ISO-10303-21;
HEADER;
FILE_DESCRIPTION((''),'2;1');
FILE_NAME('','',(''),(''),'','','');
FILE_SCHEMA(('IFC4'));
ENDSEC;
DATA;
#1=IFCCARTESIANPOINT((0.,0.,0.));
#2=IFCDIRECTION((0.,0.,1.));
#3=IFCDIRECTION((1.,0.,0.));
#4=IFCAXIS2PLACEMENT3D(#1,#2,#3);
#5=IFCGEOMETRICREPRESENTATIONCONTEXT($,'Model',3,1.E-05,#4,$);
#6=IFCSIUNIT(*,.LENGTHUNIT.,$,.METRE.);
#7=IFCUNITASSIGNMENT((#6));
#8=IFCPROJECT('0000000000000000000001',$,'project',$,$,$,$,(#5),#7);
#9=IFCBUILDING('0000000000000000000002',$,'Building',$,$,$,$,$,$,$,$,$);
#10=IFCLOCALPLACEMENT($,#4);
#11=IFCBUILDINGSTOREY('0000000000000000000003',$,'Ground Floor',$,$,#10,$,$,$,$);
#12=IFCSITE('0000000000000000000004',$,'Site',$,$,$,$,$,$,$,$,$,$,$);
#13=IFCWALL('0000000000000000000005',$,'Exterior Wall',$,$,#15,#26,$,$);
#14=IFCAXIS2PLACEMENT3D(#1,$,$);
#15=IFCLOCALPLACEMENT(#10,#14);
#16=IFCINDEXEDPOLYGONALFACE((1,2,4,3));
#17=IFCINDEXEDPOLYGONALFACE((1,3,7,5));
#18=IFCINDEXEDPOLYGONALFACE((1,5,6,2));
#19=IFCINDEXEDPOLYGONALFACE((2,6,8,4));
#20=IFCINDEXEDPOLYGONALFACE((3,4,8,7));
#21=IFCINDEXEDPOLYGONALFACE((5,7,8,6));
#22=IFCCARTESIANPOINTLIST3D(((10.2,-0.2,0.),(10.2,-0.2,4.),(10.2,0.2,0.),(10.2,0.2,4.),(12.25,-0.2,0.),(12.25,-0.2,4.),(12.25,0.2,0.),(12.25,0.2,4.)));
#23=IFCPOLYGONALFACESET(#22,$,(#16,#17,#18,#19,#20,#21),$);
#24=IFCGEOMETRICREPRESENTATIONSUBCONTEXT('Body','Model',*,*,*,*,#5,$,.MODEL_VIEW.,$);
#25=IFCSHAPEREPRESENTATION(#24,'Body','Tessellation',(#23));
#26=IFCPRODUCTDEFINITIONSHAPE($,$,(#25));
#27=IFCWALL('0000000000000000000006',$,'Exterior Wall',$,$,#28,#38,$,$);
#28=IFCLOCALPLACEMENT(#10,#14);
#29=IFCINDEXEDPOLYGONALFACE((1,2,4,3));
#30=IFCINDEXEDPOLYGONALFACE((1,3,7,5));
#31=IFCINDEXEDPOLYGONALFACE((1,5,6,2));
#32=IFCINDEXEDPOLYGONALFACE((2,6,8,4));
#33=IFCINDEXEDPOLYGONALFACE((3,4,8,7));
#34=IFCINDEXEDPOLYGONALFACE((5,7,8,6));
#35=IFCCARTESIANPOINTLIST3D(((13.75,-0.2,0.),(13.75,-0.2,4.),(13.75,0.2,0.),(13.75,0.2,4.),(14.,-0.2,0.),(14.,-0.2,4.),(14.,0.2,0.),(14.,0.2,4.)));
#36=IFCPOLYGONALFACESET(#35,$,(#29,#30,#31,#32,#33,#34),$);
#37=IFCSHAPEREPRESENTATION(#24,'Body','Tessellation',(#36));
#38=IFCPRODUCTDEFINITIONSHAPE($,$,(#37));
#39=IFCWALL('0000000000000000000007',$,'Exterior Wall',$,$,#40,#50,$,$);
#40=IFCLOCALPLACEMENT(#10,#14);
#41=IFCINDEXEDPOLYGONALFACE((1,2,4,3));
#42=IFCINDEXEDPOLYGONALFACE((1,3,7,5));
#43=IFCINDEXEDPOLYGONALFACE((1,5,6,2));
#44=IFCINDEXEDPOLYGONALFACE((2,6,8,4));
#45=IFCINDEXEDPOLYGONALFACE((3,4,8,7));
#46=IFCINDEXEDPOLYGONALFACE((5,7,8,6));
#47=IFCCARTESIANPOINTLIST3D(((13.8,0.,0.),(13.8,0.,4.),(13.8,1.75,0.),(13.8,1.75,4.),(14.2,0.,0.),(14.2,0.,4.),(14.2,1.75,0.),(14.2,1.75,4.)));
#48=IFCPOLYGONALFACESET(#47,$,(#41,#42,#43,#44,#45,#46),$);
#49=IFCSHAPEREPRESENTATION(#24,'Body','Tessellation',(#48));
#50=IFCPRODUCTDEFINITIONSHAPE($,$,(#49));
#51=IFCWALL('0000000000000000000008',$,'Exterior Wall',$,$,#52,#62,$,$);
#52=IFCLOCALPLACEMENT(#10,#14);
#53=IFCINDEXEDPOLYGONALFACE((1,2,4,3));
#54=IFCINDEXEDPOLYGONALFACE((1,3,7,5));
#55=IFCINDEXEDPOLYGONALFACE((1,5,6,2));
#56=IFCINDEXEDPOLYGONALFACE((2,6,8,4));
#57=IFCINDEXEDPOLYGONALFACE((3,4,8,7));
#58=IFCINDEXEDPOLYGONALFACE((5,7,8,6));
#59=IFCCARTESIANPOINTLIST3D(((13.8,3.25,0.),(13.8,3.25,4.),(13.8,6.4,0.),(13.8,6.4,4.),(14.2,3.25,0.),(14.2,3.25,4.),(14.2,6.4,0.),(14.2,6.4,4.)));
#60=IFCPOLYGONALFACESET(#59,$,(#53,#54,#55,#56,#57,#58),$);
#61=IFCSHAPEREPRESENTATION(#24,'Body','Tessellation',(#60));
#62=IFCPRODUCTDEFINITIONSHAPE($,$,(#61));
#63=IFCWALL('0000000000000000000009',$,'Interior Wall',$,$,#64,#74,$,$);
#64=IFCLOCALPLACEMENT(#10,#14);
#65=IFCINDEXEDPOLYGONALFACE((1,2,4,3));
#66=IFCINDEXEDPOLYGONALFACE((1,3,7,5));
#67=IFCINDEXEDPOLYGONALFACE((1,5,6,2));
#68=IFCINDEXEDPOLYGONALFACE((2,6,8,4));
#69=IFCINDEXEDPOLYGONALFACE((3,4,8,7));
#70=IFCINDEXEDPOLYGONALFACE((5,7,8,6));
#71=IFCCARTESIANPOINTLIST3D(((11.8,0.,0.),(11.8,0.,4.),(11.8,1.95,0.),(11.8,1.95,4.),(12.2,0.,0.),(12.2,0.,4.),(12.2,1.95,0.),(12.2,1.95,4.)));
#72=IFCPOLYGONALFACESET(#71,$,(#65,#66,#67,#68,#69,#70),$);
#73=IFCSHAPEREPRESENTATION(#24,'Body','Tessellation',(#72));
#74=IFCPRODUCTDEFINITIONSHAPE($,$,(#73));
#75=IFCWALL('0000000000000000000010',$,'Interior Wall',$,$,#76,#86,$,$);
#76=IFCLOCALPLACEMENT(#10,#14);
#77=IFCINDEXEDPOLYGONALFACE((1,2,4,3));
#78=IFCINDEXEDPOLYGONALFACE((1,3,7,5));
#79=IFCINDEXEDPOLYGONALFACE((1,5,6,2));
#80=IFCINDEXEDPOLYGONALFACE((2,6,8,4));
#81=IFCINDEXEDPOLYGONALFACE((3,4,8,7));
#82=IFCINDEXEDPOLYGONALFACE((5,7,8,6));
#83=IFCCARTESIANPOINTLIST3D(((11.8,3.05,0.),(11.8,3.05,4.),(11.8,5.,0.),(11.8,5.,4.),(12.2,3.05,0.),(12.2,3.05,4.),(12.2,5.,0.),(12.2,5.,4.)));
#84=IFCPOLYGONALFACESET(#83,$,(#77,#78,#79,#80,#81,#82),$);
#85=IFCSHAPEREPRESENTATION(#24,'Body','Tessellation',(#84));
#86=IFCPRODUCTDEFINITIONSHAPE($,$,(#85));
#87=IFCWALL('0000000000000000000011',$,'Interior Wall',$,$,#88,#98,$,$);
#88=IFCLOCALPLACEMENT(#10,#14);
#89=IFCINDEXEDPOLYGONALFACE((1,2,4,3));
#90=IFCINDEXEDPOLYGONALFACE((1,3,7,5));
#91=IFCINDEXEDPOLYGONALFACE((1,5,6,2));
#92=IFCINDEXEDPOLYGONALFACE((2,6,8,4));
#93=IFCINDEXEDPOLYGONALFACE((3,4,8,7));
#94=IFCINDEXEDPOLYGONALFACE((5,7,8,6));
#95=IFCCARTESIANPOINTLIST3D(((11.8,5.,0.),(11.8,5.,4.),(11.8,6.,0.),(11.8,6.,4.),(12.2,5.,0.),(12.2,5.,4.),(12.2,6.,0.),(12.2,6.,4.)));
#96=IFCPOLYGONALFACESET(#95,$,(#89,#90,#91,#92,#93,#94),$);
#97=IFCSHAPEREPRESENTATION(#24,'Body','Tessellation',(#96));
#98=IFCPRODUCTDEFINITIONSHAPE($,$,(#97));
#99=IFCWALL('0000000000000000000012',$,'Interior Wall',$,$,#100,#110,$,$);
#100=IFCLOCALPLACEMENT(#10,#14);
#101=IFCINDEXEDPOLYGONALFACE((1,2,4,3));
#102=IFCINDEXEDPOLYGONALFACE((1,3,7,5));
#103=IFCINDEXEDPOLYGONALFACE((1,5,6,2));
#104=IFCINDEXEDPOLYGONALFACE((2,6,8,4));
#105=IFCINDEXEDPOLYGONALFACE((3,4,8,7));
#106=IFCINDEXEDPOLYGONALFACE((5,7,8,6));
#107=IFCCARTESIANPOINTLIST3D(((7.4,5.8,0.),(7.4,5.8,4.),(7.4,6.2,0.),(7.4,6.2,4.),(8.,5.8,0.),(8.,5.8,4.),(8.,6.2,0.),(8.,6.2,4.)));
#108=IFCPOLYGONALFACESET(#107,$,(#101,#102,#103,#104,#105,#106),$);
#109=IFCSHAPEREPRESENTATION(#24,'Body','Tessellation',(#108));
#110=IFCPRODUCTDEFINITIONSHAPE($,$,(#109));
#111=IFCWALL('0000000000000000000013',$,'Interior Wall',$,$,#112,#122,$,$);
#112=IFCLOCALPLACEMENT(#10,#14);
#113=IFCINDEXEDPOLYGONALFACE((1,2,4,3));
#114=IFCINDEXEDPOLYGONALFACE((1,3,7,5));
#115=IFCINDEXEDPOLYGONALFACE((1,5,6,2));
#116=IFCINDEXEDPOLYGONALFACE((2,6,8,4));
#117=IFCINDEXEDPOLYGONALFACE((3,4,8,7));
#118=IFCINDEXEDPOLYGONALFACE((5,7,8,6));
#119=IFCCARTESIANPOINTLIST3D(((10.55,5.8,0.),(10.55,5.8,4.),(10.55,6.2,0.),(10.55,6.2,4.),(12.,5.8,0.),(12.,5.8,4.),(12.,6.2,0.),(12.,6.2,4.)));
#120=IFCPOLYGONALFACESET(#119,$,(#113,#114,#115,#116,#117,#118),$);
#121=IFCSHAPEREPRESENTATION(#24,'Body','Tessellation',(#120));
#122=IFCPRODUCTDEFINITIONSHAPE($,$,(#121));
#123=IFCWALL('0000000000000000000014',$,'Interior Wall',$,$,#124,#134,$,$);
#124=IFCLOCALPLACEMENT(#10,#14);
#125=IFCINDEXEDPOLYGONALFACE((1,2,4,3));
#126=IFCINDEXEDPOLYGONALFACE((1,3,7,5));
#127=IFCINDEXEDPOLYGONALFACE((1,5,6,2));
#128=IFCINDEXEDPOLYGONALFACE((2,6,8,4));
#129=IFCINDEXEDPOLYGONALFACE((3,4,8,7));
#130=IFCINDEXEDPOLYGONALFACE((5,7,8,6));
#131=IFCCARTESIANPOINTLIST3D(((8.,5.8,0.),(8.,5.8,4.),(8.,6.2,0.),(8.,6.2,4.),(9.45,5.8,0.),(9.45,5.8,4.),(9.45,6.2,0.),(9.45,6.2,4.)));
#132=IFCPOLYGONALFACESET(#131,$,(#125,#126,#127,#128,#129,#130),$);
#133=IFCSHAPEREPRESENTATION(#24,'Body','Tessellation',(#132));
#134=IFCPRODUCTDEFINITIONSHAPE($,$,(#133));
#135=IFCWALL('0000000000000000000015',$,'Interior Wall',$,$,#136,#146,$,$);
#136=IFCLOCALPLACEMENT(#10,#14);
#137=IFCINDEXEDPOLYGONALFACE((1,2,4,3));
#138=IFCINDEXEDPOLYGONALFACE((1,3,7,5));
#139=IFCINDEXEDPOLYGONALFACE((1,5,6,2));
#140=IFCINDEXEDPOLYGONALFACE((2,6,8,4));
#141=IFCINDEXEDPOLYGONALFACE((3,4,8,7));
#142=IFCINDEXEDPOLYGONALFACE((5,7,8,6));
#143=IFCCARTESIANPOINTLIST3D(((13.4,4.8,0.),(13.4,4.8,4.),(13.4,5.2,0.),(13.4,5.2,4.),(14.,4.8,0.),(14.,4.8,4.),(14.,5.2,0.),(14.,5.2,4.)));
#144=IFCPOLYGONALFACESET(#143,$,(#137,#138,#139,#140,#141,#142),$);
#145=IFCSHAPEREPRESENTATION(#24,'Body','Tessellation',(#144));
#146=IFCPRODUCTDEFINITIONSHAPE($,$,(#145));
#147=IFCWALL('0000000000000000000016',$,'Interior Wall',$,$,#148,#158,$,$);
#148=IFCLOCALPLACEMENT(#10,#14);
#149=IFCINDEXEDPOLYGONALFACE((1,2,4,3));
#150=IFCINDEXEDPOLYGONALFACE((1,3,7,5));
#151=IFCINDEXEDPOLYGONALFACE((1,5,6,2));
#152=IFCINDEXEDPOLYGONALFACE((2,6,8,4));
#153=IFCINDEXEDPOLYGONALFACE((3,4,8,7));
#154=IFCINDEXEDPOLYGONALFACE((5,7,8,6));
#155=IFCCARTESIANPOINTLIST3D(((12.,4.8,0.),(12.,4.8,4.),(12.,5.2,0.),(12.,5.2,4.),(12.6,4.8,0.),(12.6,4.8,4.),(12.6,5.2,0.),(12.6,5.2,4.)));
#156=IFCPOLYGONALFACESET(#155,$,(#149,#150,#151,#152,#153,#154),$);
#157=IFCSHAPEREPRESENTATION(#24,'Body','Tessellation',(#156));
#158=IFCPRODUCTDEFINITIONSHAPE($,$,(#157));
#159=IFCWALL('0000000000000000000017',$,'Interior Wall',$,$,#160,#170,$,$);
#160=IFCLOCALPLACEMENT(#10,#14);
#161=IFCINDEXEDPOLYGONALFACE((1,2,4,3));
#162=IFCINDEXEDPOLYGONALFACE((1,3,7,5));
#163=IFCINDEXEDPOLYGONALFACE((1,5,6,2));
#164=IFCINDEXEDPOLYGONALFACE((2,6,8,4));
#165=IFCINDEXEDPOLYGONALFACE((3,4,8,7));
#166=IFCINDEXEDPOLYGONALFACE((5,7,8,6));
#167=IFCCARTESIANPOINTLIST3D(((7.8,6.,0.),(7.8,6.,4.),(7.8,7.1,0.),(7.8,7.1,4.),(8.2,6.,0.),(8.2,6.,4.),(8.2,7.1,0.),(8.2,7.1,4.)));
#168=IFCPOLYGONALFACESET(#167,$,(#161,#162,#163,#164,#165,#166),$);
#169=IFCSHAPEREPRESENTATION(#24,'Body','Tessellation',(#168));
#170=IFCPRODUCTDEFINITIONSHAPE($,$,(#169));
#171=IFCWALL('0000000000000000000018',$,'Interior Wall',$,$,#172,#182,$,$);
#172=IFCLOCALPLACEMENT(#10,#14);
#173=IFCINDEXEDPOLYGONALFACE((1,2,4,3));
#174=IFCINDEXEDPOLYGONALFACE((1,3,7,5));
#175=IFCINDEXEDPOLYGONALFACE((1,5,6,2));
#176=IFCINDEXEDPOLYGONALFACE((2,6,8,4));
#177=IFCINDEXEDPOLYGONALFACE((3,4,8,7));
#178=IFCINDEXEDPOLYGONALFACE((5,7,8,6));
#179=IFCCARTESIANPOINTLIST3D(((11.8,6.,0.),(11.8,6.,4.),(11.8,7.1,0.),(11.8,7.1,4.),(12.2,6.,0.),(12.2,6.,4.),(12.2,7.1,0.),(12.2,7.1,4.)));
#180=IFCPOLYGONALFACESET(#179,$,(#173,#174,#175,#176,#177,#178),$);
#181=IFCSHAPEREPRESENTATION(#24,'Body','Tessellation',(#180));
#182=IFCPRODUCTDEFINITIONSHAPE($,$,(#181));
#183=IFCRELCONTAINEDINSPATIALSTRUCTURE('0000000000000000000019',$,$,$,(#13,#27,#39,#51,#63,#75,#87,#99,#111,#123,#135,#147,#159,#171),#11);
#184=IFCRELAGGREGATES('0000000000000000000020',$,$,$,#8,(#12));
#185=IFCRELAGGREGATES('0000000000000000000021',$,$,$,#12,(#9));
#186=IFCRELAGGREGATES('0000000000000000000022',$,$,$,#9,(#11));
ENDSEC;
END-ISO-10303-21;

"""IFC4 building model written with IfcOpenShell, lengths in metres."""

from ifc_helpers import new_model, si_unit, frame, origin_with_axes, place, context, subcontext, project, spatial, indexed_curve, outline, extrude, element, save


model = new_model("IFC4")

# Units and contexts
model_context = context("Model", 3, precision=1e-05, world=origin_with_axes())
body_context = subcontext(model_context, "Body", "Model", "MODEL_VIEW")
ifc_project = project(units=[si_unit("LENGTHUNIT", "METRE")], contexts=[model_context])

# Site, building, storey
site = spatial("IfcSite", under=ifc_project, Name="Site")
building = spatial("IfcBuilding", under=site, Name="Building")
storey_placement = place(None, origin_with_axes())
storey = spatial("IfcBuildingStorey", under=building, at=storey_placement, Name="Ground Floor")

# Walls
wall_1_placement = place(storey_placement, frame((10.2, 0.0, 0.0), z_axis=(0.0, 0.0, 1.0), x_axis=(1.0, 0.0, 0.0)))
element("IfcWall", 1, at=wall_1_placement, inside=storey, Name="Exterior Wall", context=body_context, shape_type="SweptSolid", body=[
    extrude(outline(indexed_curve([(0.0, 0.0), (0.0, 0.4), (2.05, 0.4), (2.05, 0.0), (0.0, 0.0)], self_intersect=False)), frame((0.0, -0.2, 0.0), z_axis=(0.0, 0.0, 1.0), x_axis=(1.0, 0.0, 0.0)), (0.0, 0.0, 1.0), 4.0),
])
wall_2_placement = place(storey_placement, frame((13.75, 0.0, 0.0), z_axis=(0.0, 0.0, 1.0), x_axis=(1.0, 0.0, 0.0)))
element("IfcWall", 2, at=wall_2_placement, inside=storey, Name="Exterior Wall", context=body_context, shape_type="SweptSolid", body=[
    extrude(outline(indexed_curve([(0.0, 0.0), (0.0, 0.4), (0.25, 0.4), (0.25, 0.0), (0.0, 0.0)], self_intersect=False)), frame((0.0, -0.2, 0.0), z_axis=(0.0, 0.0, 1.0), x_axis=(1.0, 0.0, 0.0)), (0.0, 0.0, 1.0), 4.0),
])
wall_3_placement = place(storey_placement, frame((14.0, 0.0, 0.0), z_axis=(0.0, 0.0, 1.0), x_axis=(0.0, 1.0, 0.0)))
element("IfcWall", 3, at=wall_3_placement, inside=storey, Name="Exterior Wall", context=body_context, shape_type="SweptSolid", body=[
    extrude(outline(indexed_curve([(0.0, 0.0), (0.0, 0.4), (1.75, 0.4), (1.75, 0.0), (0.0, 0.0)], self_intersect=False)), frame((0.0, -0.2, 0.0), z_axis=(0.0, 0.0, 1.0), x_axis=(1.0, 0.0, 0.0)), (0.0, 0.0, 1.0), 4.0),
])
wall_4_placement = place(storey_placement, frame((14.0, 3.25, 0.0), z_axis=(0.0, 0.0, 1.0), x_axis=(0.0, 1.0, 0.0)))
element("IfcWall", 4, at=wall_4_placement, inside=storey, Name="Exterior Wall", context=body_context, shape_type="SweptSolid", body=[
    extrude(outline(indexed_curve([(0.0, 0.0), (0.0, 0.4), (3.15, 0.4), (3.15, 0.0), (0.0, 0.0)], self_intersect=False)), frame((0.0, -0.2, 0.0), z_axis=(0.0, 0.0, 1.0), x_axis=(1.0, 0.0, 0.0)), (0.0, 0.0, 1.0), 4.0),
])
wall_5_placement = place(storey_placement, frame((12.0, 0.0, 0.0), z_axis=(0.0, 0.0, 1.0), x_axis=(0.0, 1.0, 0.0)))
element("IfcWall", 5, at=wall_5_placement, inside=storey, Name="Interior Wall", context=body_context, shape_type="SweptSolid", body=[
    extrude(outline(indexed_curve([(0.0, 0.0), (0.0, 0.4), (1.95, 0.4), (1.95, 0.0), (0.0, 0.0)], self_intersect=False)), frame((0.0, -0.2, 0.0), z_axis=(0.0, 0.0, 1.0), x_axis=(1.0, 0.0, 0.0)), (0.0, 0.0, 1.0), 4.0),
])
wall_6_placement = place(storey_placement, frame((12.0, 3.05, 0.0), z_axis=(0.0, 0.0, 1.0), x_axis=(0.0, 1.0, 0.0)))
element("IfcWall", 6, at=wall_6_placement, inside=storey, Name="Interior Wall", context=body_context, shape_type="SweptSolid", body=[
    extrude(outline(indexed_curve([(0.0, 0.0), (0.0, 0.4), (1.95, 0.4), (1.95, 0.0), (0.0, 0.0)], self_intersect=False)), frame((0.0, -0.2, 0.0), z_axis=(0.0, 0.0, 1.0), x_axis=(1.0, 0.0, 0.0)), (0.0, 0.0, 1.0), 4.0),
])
wall_7_placement = place(storey_placement, frame((12.0, 5.0, 0.0), z_axis=(0.0, 0.0, 1.0), x_axis=(0.0, 1.0, 0.0)))
element("IfcWall", 7, at=wall_7_placement, inside=storey, Name="Interior Wall", context=body_context, shape_type="SweptSolid", body=[
    extrude(outline(indexed_curve([(0.0, 0.0), (0.0, 0.4), (1.0, 0.4), (1.0, 0.0), (0.0, 0.0)], self_intersect=False)), frame((0.0, -0.2, 0.0), z_axis=(0.0, 0.0, 1.0), x_axis=(1.0, 0.0, 0.0)), (0.0, 0.0, 1.0), 4.0),
])
wall_8_placement = place(storey_placement, frame((8.0, 6.0, 0.0), z_axis=(0.0, 0.0, 1.0), x_axis=(-1.0, 0.0, 0.0)))
element("IfcWall", 8, at=wall_8_placement, inside=storey, Name="Interior Wall", context=body_context, shape_type="SweptSolid", body=[
    extrude(outline(indexed_curve([(0.0, 0.0), (0.0, 0.4), (0.6, 0.4), (0.6, 0.0), (0.0, 0.0)], self_intersect=False)), frame((0.0, -0.2, 0.0), z_axis=(0.0, 0.0, 1.0), x_axis=(1.0, 0.0, 0.0)), (0.0, 0.0, 1.0), 4.0),
])
for number, where, z_axis, x_axis, name in (
    (9, (12.0, 6.0, 0.0), (0.0, 0.0, 1.0), (-1.0, 0.0, 0.0), "Interior Wall"),
    (10, (9.45, 6.0, 0.0), (0.0, 0.0, 1.0), (-1.0, 0.0, 0.0), "Interior Wall"),
):
    element("IfcWall", number, at=place(storey_placement, frame(where, z_axis=z_axis, x_axis=x_axis)), inside=storey, Name=name, context=body_context, shape_type="SweptSolid", body=[
        extrude(outline(indexed_curve([(0.0, 0.0), (0.0, 0.4), (1.45, 0.4), (1.45, 0.0), (0.0, 0.0)], self_intersect=False)), frame((0.0, -0.2, 0.0), z_axis=(0.0, 0.0, 1.0), x_axis=(1.0, 0.0, 0.0)), (0.0, 0.0, 1.0), 4.0),
    ])
for number, where, z_axis, x_axis, name in (
    (11, (14.0, 5.0, 0.0), (0.0, 0.0, 1.0), (-1.0, 0.0, 0.0), "Interior Wall"),
    (12, (12.6, 5.0, 0.0), (0.0, 0.0, 1.0), (-1.0, 0.0, 0.0), "Interior Wall"),
):
    element("IfcWall", number, at=place(storey_placement, frame(where, z_axis=z_axis, x_axis=x_axis)), inside=storey, Name=name, context=body_context, shape_type="SweptSolid", body=[
        extrude(outline(indexed_curve([(0.0, 0.0), (0.0, 0.4), (0.6, 0.4), (0.6, 0.0), (0.0, 0.0)], self_intersect=False)), frame((0.0, -0.2, 0.0), z_axis=(0.0, 0.0, 1.0), x_axis=(1.0, 0.0, 0.0)), (0.0, 0.0, 1.0), 4.0),
    ])
for number, where, z_axis, x_axis, name in (
    (13, (8.0, 6.0, 0.0), (0.0, 0.0, 1.0), (0.0, 1.0, 0.0), "Interior Wall"),
    (14, (12.0, 6.0, 0.0), (0.0, 0.0, 1.0), (0.0, 1.0, 0.0), "Interior Wall"),
):
    element("IfcWall", number, at=place(storey_placement, frame(where, z_axis=z_axis, x_axis=x_axis)), inside=storey, Name=name, context=body_context, shape_type="SweptSolid", body=[
        extrude(outline(indexed_curve([(0.0, 0.0), (0.0, 0.4), (1.1, 0.4), (1.1, 0.0), (0.0, 0.0)], self_intersect=False)), frame((0.0, -0.2, 0.0), z_axis=(0.0, 0.0, 1.0), x_axis=(1.0, 0.0, 0.0)), (0.0, 0.0, 1.0), 4.0),
    ])

save(model, "model.ifc")
